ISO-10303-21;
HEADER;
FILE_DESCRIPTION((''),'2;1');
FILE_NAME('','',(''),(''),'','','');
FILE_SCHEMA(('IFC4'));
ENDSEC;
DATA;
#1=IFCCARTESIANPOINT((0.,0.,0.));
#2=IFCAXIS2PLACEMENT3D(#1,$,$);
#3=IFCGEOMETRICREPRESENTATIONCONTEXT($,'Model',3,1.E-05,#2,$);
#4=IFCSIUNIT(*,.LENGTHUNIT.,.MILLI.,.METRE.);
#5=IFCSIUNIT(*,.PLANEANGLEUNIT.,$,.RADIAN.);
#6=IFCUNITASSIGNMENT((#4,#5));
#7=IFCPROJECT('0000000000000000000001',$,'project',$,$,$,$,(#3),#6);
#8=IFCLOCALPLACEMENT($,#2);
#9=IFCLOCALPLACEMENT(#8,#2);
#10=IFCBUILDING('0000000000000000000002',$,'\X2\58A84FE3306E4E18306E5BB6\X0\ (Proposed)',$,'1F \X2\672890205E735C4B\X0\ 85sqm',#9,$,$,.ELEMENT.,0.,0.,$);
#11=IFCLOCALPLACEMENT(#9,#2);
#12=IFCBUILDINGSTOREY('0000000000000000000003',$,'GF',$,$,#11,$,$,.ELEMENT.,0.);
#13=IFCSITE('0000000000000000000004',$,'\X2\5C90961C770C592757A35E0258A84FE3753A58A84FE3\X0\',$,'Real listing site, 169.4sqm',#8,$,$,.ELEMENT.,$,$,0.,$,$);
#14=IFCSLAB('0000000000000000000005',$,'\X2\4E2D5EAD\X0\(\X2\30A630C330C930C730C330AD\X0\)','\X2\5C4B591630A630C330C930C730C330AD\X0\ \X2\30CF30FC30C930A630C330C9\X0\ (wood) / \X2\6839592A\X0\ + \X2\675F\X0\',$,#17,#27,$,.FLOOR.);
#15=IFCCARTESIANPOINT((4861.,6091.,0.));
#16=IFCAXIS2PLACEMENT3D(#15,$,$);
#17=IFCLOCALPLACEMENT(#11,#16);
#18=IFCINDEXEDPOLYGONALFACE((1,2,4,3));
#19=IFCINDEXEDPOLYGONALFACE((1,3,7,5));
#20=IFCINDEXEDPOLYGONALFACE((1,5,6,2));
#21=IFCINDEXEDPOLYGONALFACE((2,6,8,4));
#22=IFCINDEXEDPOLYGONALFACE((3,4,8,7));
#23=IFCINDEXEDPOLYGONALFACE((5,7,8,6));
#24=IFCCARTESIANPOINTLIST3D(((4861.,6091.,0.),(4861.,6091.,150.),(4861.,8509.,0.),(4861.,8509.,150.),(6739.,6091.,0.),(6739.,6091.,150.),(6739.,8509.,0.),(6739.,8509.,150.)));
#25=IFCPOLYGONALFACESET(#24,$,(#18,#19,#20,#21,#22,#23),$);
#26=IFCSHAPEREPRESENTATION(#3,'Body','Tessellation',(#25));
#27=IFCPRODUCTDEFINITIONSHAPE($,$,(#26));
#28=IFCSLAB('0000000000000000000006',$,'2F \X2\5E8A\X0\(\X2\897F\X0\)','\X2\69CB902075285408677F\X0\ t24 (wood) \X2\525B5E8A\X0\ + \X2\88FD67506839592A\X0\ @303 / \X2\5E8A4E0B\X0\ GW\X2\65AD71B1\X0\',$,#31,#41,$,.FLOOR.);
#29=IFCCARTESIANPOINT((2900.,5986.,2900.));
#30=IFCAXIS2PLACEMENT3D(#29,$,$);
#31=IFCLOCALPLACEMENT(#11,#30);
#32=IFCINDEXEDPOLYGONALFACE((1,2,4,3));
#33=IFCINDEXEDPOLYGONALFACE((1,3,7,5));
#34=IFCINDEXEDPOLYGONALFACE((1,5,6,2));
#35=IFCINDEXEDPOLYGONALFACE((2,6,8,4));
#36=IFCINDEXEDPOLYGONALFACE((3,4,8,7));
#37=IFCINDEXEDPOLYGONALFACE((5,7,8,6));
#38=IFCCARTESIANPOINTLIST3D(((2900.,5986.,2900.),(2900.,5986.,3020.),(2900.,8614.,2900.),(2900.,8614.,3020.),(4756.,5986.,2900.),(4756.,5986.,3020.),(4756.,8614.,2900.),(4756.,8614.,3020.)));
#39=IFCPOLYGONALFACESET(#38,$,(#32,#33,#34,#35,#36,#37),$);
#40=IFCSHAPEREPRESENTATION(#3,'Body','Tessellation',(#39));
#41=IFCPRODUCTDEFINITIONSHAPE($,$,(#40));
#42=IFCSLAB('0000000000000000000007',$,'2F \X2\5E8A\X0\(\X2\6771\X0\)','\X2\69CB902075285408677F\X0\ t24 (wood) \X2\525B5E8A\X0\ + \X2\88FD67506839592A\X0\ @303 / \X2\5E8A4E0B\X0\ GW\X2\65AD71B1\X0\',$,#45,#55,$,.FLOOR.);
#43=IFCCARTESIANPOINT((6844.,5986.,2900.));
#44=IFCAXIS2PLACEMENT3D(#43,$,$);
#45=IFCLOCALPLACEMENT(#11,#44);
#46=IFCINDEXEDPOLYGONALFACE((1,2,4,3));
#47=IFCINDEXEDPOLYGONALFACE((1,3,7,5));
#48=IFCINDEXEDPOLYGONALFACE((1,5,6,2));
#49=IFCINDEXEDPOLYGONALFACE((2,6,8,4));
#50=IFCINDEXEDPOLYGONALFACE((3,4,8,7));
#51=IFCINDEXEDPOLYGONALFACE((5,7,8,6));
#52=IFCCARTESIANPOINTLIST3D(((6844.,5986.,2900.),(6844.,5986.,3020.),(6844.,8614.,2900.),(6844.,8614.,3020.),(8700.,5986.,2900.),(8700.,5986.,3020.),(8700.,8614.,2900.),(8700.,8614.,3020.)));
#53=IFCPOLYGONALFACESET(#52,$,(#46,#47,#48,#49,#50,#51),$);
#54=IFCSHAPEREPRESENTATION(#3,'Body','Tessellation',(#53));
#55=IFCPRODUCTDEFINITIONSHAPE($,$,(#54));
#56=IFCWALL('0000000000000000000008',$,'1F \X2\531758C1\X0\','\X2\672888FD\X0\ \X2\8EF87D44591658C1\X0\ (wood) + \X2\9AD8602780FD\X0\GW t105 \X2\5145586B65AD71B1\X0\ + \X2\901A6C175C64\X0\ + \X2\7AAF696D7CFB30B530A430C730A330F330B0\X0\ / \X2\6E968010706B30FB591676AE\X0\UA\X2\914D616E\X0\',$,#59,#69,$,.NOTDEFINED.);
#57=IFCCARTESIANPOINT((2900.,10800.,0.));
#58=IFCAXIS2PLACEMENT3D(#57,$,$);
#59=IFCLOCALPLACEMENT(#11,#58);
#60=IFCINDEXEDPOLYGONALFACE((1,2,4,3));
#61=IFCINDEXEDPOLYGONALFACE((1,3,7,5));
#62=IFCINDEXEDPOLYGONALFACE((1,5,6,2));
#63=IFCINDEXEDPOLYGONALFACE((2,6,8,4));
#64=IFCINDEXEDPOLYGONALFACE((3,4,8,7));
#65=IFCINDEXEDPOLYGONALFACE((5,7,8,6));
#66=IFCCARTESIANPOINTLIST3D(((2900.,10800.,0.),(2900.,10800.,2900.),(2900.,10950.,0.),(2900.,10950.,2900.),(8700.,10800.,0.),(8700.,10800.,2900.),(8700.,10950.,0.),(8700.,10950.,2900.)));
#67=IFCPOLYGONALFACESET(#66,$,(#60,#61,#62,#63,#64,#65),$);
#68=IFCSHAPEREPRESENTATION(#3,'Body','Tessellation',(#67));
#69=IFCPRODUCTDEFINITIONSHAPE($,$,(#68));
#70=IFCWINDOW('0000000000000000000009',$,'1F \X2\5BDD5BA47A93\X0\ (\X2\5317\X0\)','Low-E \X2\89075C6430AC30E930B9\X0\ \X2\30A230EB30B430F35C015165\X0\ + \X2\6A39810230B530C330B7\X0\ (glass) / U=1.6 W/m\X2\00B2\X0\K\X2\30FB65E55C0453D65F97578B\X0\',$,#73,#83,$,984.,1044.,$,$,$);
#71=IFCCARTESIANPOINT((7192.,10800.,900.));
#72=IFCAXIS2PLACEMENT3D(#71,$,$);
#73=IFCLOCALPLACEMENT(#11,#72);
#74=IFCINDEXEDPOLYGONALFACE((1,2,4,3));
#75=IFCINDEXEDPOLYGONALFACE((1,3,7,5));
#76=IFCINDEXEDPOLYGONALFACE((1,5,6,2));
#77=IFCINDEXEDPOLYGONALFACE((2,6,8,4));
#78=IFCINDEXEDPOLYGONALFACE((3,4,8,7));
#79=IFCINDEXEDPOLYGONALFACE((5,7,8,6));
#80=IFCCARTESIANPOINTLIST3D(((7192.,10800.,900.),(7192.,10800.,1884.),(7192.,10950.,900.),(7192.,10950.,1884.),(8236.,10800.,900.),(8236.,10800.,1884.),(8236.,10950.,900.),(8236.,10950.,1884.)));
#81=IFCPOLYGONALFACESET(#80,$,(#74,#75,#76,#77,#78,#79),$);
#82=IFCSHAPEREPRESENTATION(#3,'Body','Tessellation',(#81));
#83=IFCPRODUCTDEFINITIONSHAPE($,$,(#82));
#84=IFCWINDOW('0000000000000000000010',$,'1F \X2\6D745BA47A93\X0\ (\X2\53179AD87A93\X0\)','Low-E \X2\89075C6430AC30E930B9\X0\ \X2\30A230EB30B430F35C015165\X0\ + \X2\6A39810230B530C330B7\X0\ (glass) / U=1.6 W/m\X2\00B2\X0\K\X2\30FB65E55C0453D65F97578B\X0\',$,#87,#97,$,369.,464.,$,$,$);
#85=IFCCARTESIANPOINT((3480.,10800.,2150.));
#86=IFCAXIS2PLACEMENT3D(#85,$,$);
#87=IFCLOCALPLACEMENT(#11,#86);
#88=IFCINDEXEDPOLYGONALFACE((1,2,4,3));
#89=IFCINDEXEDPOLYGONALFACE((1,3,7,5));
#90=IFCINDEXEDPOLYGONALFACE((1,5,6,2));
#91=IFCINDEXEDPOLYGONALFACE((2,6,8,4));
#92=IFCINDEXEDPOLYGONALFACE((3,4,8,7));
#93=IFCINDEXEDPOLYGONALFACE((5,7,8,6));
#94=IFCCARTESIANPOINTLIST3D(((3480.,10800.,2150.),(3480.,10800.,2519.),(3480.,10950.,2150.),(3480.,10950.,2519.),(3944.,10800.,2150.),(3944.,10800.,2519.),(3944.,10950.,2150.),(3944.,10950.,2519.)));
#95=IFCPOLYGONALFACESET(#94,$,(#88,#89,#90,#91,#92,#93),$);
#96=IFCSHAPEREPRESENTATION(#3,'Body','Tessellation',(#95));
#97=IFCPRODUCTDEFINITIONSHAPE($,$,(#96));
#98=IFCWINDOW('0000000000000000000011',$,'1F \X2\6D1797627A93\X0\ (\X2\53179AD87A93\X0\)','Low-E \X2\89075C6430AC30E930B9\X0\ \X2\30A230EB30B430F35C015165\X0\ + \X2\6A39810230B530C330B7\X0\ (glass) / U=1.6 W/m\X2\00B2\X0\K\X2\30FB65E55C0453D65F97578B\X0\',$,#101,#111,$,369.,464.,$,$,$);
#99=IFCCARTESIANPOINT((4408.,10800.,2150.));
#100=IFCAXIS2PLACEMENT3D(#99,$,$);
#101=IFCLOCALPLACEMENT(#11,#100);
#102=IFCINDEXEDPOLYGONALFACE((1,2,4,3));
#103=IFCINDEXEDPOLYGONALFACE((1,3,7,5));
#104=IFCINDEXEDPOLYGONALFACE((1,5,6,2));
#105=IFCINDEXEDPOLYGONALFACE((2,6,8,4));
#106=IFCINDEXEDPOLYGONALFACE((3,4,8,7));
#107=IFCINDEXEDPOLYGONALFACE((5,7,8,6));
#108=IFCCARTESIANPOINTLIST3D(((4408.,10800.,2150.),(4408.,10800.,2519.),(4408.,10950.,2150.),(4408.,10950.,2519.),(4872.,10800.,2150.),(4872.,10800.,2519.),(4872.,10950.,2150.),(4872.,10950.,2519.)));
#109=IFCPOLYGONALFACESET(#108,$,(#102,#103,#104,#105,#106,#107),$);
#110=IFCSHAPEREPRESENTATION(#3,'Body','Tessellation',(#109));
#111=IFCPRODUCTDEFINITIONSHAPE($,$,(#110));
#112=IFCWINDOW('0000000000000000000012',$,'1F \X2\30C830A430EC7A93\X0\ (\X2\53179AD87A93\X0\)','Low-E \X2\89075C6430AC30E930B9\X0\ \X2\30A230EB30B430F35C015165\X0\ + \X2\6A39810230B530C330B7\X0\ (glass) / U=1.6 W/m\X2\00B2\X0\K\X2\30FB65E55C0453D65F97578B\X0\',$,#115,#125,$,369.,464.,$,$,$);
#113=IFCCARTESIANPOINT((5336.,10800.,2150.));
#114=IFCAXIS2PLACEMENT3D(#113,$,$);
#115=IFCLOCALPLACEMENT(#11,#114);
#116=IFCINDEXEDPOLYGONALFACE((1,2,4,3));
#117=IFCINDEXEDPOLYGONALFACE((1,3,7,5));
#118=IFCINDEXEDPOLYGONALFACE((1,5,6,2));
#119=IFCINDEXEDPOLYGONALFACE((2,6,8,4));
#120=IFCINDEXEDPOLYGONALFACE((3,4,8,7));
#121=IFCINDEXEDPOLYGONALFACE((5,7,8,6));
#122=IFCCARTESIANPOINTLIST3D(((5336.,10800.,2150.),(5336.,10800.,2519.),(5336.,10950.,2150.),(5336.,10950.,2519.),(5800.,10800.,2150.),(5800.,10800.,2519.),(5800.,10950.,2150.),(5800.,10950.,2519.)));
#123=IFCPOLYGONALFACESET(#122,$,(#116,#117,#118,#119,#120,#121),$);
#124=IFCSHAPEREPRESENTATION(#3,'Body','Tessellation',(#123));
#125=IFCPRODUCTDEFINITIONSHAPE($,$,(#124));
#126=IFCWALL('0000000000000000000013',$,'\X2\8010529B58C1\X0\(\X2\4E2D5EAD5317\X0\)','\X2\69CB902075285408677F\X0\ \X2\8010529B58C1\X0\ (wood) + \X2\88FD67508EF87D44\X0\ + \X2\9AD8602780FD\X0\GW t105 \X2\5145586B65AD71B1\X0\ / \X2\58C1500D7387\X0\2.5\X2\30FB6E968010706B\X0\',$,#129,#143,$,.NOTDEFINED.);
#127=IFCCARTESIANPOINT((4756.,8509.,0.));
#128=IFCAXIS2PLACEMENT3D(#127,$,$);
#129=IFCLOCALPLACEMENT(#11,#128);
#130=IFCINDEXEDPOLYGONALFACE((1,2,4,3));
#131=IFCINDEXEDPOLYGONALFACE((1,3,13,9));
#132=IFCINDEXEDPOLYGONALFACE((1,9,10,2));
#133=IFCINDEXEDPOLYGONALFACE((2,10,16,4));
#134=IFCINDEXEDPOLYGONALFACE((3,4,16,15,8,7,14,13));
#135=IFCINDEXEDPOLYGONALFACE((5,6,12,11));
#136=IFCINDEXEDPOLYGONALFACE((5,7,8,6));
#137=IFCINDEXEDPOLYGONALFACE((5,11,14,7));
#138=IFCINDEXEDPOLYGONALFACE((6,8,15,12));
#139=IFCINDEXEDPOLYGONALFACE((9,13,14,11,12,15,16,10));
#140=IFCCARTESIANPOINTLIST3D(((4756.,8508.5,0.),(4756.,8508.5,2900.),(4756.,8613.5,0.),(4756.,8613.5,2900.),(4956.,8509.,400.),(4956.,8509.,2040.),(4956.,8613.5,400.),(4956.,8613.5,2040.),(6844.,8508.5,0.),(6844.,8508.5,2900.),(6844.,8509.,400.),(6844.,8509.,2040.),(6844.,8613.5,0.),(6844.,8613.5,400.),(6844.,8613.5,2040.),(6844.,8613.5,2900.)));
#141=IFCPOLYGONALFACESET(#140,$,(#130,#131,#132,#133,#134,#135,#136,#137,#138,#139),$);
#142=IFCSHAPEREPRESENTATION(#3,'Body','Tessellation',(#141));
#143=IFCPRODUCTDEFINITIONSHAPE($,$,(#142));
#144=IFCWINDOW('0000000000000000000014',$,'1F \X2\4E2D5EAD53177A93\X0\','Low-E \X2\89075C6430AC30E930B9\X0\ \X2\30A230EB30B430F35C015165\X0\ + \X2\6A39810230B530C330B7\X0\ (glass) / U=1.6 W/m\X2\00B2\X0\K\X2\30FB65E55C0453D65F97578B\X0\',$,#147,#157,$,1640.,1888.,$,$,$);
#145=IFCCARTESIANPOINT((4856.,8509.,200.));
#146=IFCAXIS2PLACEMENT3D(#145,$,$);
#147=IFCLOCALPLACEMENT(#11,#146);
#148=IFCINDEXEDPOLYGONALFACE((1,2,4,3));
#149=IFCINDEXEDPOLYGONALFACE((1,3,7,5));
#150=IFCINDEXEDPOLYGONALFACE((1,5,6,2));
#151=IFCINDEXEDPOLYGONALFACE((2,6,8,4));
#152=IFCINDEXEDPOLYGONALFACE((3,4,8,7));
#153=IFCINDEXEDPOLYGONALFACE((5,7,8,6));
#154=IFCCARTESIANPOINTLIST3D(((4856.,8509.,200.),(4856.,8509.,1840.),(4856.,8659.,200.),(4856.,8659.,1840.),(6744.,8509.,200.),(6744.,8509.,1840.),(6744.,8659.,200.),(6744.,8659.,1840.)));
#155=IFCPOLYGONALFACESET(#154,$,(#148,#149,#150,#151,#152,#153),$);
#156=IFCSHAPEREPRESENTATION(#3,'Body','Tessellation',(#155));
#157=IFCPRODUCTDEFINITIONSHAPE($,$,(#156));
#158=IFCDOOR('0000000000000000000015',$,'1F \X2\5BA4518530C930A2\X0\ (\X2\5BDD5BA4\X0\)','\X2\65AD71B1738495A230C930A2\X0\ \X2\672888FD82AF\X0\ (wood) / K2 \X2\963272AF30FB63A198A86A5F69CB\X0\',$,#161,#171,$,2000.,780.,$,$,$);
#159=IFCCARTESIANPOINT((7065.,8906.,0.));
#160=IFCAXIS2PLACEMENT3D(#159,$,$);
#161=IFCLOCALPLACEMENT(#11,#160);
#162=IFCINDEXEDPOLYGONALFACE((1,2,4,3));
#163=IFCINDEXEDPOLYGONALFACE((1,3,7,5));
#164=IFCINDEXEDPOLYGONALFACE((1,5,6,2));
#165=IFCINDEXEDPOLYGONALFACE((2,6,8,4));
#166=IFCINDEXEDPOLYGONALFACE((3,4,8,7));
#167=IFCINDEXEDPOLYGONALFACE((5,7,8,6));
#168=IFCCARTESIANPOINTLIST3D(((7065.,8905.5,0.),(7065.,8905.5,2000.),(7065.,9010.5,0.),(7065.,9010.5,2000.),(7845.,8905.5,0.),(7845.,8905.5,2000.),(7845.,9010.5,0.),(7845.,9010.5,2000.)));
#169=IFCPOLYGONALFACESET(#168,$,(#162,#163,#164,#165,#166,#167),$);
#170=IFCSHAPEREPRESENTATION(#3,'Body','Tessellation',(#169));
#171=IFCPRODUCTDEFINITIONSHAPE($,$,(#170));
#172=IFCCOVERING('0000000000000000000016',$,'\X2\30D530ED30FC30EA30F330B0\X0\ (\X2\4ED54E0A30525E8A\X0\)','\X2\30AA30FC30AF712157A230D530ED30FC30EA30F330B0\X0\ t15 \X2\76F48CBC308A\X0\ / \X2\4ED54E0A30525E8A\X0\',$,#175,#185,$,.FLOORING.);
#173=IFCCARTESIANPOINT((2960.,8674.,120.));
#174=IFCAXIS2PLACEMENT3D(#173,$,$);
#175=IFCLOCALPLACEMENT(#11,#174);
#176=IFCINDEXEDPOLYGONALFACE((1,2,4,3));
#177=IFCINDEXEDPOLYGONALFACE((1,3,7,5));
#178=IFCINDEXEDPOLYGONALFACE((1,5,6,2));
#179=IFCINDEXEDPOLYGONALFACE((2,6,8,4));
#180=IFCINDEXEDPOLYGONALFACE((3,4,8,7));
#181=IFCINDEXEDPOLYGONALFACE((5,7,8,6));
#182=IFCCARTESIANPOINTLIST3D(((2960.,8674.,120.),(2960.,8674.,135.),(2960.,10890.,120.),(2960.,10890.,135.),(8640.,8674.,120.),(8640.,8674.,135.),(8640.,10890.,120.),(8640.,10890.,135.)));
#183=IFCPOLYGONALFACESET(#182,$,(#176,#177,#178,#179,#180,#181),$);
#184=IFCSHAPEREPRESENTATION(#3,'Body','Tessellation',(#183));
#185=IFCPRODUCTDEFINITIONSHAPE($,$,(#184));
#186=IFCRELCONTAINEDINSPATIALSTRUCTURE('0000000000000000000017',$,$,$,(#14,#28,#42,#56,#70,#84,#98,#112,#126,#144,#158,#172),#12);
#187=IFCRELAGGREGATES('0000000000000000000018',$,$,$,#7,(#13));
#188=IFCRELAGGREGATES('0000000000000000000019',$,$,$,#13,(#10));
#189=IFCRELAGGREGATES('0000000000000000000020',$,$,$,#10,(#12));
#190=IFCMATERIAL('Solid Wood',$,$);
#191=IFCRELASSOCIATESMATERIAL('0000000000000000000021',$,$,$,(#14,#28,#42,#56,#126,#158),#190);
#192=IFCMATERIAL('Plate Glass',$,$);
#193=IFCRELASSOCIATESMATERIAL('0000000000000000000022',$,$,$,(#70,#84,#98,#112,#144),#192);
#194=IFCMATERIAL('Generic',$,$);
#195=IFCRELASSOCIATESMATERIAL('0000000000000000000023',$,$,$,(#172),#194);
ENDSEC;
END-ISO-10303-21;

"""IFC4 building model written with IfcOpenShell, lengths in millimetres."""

from ifc_helpers import new_model, si_unit, frame, frame_2d, origin, place, context, project, spatial, rectangle, extrude, material, element, fill, save


model = new_model("IFC4")

# Units and contexts
model_context = context("Model", 3, precision=1e-05, world=origin())
ifc_project = project(units=[si_unit("LENGTHUNIT", "METRE", prefix="MILLI"), si_unit("PLANEANGLEUNIT", "RADIAN")], contexts=[model_context])

# Site, building, storey
site_placement = place(None, origin())
site = spatial("IfcSite", under=ifc_project, at=site_placement, Name="岐阜県大垣市墨俣町墨俣", ObjectType="Real listing site, 169.4sqm", CompositionType="ELEMENT", RefElevation=0.0)
building_placement = place(site_placement, origin())
building = spatial("IfcBuilding", under=site, at=building_placement, Name="墨俣の丘の家 (Proposed)", ObjectType="1F 木造平屋 85sqm", CompositionType="ELEMENT", ElevationOfRefHeight=0.0, ElevationOfTerrain=0.0)
storey_placement = place(building_placement, origin())
storey = spatial("IfcBuildingStorey", under=building, at=storey_placement, Name="GF", CompositionType="ELEMENT", Elevation=0.0)

# Slabs
ifc_material_1 = material(Name="Solid Wood")
slab_1_placement = place(storey_placement, frame((4861.0, 6091.0, 0.0)))
element("IfcSlab", 1, at=slab_1_placement, inside=storey, material=ifc_material_1, Name="中庭(ウッドデッキ)", Description="屋外ウッドデッキ ハードウッド (wood) / 根太 + 束", PredefinedType="FLOOR", context=model_context, shape_type="SweptSolid", body=[
    extrude(rectangle(XDim=1878.0, YDim=2418.0, at=frame_2d((939.0, 1209.0))), frame((4861.0, 6091.0, 0.0)), (0.0, 0.0, 1.0), 150.0),
])
slab_2_placement = place(storey_placement, frame((2900.0, 5986.0, 2900.0)))
element("IfcSlab", 2, at=slab_2_placement, inside=storey, material=ifc_material_1, Name="2F 床(西)", Description="構造用合板 t24 (wood) 剛床 + 製材根太 @303 / 床下 GW断熱", PredefinedType="FLOOR", context=model_context, shape_type="SweptSolid", body=[
    extrude(rectangle(XDim=1856.0, YDim=2628.0, at=frame_2d((928.0, 1314.0))), frame((2900.0, 5986.0, 2900.0)), (0.0, 0.0, 1.0), 120.0),
])
slab_3_placement = place(storey_placement, frame((6844.0, 5986.0, 2900.0)))
element("IfcSlab", 3, at=slab_3_placement, inside=storey, material=ifc_material_1, Name="2F 床(東)", Description="構造用合板 t24 (wood) 剛床 + 製材根太 @303 / 床下 GW断熱", PredefinedType="FLOOR", context=model_context, shape_type="SweptSolid", body=[
    extrude(rectangle(XDim=1856.0, YDim=2628.0, at=frame_2d((928.0, 1314.0))), frame((6844.0, 5986.0, 2900.0)), (0.0, 0.0, 1.0), 120.0),
])

# Wall, openings, windows
wall_1_placement = place(storey_placement, frame((2900.0, 10800.0, 0.0)))
wall_1 = element("IfcWall", 4, at=wall_1_placement, inside=storey, material=ifc_material_1, Name="1F 北壁", Description="木製 軸組外壁 (wood) + 高性能GW t105 充填断熱 + 通気層 + 窯業系サイディング / 準耐火・外皮UA配慮", PredefinedType="NOTDEFINED", context=model_context, shape_type="SweptSolid", body=[
    extrude(rectangle(XDim=5800.0, YDim=150.0, at=frame_2d((2900.0, 75.0))), frame((2900.0, 10800.0, 0.0)), (0.0, 0.0, 1.0), 2900.0),
])
opening_1_placement = place(storey_placement, frame((7192.0, 10800.0, 900.0)))
opening_1 = element("IfcOpeningElement", 5, at=opening_1_placement, cuts=wall_1, PredefinedType="NOTDEFINED", context=model_context, shape_type="SweptSolid", body=[
    extrude(rectangle(XDim=1044.0, YDim=150.0, at=frame_2d((522.0, 75.0))), frame((7192.0, 10800.0, 900.0)), (0.0, 0.0, 1.0), 984.0),
])
opening_2_placement = place(storey_placement, frame((3480.0, 10800.0, 2150.0)))
opening_2 = element("IfcOpeningElement", 6, at=opening_2_placement, cuts=wall_1, PredefinedType="NOTDEFINED", context=model_context, shape_type="SweptSolid", body=[
    extrude(rectangle(XDim=464.0, YDim=150.0, at=frame_2d((232.0, 75.0))), frame((3480.0, 10800.0, 2150.0)), (0.0, 0.0, 1.0), 369.0),
])
opening_3_placement = place(storey_placement, frame((4408.0, 10800.0, 2150.0)))
opening_3 = element("IfcOpeningElement", 7, at=opening_3_placement, cuts=wall_1, PredefinedType="NOTDEFINED", context=model_context, shape_type="SweptSolid", body=[
    extrude(rectangle(XDim=464.0, YDim=150.0, at=frame_2d((232.0, 75.0))), frame((4408.0, 10800.0, 2150.0)), (0.0, 0.0, 1.0), 369.0),
])
opening_4_placement = place(storey_placement, frame((5336.0, 10800.0, 2150.0)))
opening_4 = element("IfcOpeningElement", 8, at=opening_4_placement, cuts=wall_1, PredefinedType="NOTDEFINED", context=model_context, shape_type="SweptSolid", body=[
    extrude(rectangle(XDim=464.0, YDim=150.0, at=frame_2d((232.0, 75.0))), frame((5336.0, 10800.0, 2150.0)), (0.0, 0.0, 1.0), 369.0),
])
ifc_material_2 = material(Name="Plate Glass")
window_1_placement = place(storey_placement, frame((7192.0, 10800.0, 900.0)))
window_1 = element("IfcWindow", 9, at=window_1_placement, inside=storey, material=ifc_material_2, Name="1F 寝室窓 (北)", Description="Low-E 複層ガラス アルゴン封入 + 樹脂サッシ (glass) / U=1.6 W/m²K・日射取得型", OverallHeight=984.0, OverallWidth=1044.0, context=model_context, shape_type="SweptSolid", body=[
    extrude(rectangle(XDim=1044.0, YDim=150.0, at=frame_2d((522.0, 75.0))), frame((7192.0, 10800.0, 900.0)), (0.0, 0.0, 1.0), 984.0),
])
fill(opening_1, window_1)
window_2_placement = place(storey_placement, frame((3480.0, 10800.0, 2150.0)))
window_2 = element("IfcWindow", 10, at=window_2_placement, inside=storey, material=ifc_material_2, Name="1F 浴室窓 (北高窓)", Description="Low-E 複層ガラス アルゴン封入 + 樹脂サッシ (glass) / U=1.6 W/m²K・日射取得型", OverallHeight=369.0, OverallWidth=464.0, context=model_context, shape_type="SweptSolid", body=[
    extrude(rectangle(XDim=464.0, YDim=150.0, at=frame_2d((232.0, 75.0))), frame((3480.0, 10800.0, 2150.0)), (0.0, 0.0, 1.0), 369.0),
])
fill(opening_2, window_2)
window_3_placement = place(storey_placement, frame((4408.0, 10800.0, 2150.0)))
window_3 = element("IfcWindow", 11, at=window_3_placement, inside=storey, material=ifc_material_2, Name="1F 洗面窓 (北高窓)", Description="Low-E 複層ガラス アルゴン封入 + 樹脂サッシ (glass) / U=1.6 W/m²K・日射取得型", OverallHeight=369.0, OverallWidth=464.0, context=model_context, shape_type="SweptSolid", body=[
    extrude(rectangle(XDim=464.0, YDim=150.0, at=frame_2d((232.0, 75.0))), frame((4408.0, 10800.0, 2150.0)), (0.0, 0.0, 1.0), 369.0),
])
fill(opening_3, window_3)
window_4_placement = place(storey_placement, frame((5336.0, 10800.0, 2150.0)))
window_4 = element("IfcWindow", 12, at=window_4_placement, inside=storey, material=ifc_material_2, Name="1F トイレ窓 (北高窓)", Description="Low-E 複層ガラス アルゴン封入 + 樹脂サッシ (glass) / U=1.6 W/m²K・日射取得型", OverallHeight=369.0, OverallWidth=464.0, context=model_context, shape_type="SweptSolid", body=[
    extrude(rectangle(XDim=464.0, YDim=150.0, at=frame_2d((232.0, 75.0))), frame((5336.0, 10800.0, 2150.0)), (0.0, 0.0, 1.0), 369.0),
])
fill(opening_4, window_4)

# Wall, opening, window
wall_2_placement = place(storey_placement, frame((4756.0, 8509.0, 0.0)))
wall_2 = element("IfcWall", 13, at=wall_2_placement, inside=storey, material=ifc_material_1, Name="耐力壁(中庭北)", Description="構造用合板 耐力壁 (wood) + 製材軸組 + 高性能GW t105 充填断熱 / 壁倍率2.5・準耐火", PredefinedType="NOTDEFINED", context=model_context, shape_type="SweptSolid", body=[
    extrude(rectangle(XDim=2088.0, YDim=105.0, at=frame_2d((1044.0, 52.0))), frame((4756.0, 8509.0, 0.0)), (0.0, 0.0, 1.0), 2900.0),
])
opening_5_placement = place(storey_placement, frame((4856.0, 8509.0, 200.0)))
opening_5 = element("IfcOpeningElement", 14, at=opening_5_placement, cuts=wall_2, PredefinedType="NOTDEFINED", context=model_context, shape_type="SweptSolid", body=[
    extrude(rectangle(XDim=1888.0, YDim=150.0, at=frame_2d((944.0, 75.0))), frame((4856.0, 8509.0, 200.0)), (0.0, 0.0, 1.0), 1640.0),
])
window_5_placement = place(storey_placement, frame((4856.0, 8509.0, 200.0)))
window_5 = element("IfcWindow", 15, at=window_5_placement, inside=storey, material=ifc_material_2, Name="1F 中庭北窓", Description="Low-E 複層ガラス アルゴン封入 + 樹脂サッシ (glass) / U=1.6 W/m²K・日射取得型", OverallHeight=1640.0, OverallWidth=1888.0, context=model_context, shape_type="SweptSolid", body=[
    extrude(rectangle(XDim=1888.0, YDim=150.0, at=frame_2d((944.0, 75.0))), frame((4856.0, 8509.0, 200.0)), (0.0, 0.0, 1.0), 1640.0),
])
fill(opening_5, window_5)

# Door
door_1_placement = place(storey_placement, frame((7065.0, 8906.0, 0.0)))
element("IfcDoor", 16, at=door_1_placement, inside=storey, material=ifc_material_1, Name="1F 室内ドア (寝室)", Description="断熱玄関ドア 木製芯 (wood) / K2 防犯・採風機構", OverallHeight=2000.0, OverallWidth=780.0, context=model_context, shape_type="SweptSolid", body=[
    extrude(rectangle(XDim=780.0, YDim=105.0, at=frame_2d((390.0, 52.0))), frame((7065.0, 8906.0, 0.0)), (0.0, 0.0, 1.0), 2000.0),
])

# Covering
ifc_material_3 = material(Name="Generic")
covering_1_placement = place(storey_placement, frame((2960.0, 8674.0, 120.0)))
element("IfcCovering", 17, at=covering_1_placement, inside=storey, material=ifc_material_3, Name="フローリング (仕上げ床)", Description="オーク無垢フローリング t15 直貼り / 仕上げ床", PredefinedType="FLOORING", context=model_context, shape_type="SweptSolid", body=[
    extrude(rectangle(XDim=5680.0, YDim=2216.0, at=frame_2d((2840.0, 1108.0))), frame((2960.0, 8674.0, 120.0)), (0.0, 0.0, 1.0), 15.0),
])

save(model, "model.ifc")
